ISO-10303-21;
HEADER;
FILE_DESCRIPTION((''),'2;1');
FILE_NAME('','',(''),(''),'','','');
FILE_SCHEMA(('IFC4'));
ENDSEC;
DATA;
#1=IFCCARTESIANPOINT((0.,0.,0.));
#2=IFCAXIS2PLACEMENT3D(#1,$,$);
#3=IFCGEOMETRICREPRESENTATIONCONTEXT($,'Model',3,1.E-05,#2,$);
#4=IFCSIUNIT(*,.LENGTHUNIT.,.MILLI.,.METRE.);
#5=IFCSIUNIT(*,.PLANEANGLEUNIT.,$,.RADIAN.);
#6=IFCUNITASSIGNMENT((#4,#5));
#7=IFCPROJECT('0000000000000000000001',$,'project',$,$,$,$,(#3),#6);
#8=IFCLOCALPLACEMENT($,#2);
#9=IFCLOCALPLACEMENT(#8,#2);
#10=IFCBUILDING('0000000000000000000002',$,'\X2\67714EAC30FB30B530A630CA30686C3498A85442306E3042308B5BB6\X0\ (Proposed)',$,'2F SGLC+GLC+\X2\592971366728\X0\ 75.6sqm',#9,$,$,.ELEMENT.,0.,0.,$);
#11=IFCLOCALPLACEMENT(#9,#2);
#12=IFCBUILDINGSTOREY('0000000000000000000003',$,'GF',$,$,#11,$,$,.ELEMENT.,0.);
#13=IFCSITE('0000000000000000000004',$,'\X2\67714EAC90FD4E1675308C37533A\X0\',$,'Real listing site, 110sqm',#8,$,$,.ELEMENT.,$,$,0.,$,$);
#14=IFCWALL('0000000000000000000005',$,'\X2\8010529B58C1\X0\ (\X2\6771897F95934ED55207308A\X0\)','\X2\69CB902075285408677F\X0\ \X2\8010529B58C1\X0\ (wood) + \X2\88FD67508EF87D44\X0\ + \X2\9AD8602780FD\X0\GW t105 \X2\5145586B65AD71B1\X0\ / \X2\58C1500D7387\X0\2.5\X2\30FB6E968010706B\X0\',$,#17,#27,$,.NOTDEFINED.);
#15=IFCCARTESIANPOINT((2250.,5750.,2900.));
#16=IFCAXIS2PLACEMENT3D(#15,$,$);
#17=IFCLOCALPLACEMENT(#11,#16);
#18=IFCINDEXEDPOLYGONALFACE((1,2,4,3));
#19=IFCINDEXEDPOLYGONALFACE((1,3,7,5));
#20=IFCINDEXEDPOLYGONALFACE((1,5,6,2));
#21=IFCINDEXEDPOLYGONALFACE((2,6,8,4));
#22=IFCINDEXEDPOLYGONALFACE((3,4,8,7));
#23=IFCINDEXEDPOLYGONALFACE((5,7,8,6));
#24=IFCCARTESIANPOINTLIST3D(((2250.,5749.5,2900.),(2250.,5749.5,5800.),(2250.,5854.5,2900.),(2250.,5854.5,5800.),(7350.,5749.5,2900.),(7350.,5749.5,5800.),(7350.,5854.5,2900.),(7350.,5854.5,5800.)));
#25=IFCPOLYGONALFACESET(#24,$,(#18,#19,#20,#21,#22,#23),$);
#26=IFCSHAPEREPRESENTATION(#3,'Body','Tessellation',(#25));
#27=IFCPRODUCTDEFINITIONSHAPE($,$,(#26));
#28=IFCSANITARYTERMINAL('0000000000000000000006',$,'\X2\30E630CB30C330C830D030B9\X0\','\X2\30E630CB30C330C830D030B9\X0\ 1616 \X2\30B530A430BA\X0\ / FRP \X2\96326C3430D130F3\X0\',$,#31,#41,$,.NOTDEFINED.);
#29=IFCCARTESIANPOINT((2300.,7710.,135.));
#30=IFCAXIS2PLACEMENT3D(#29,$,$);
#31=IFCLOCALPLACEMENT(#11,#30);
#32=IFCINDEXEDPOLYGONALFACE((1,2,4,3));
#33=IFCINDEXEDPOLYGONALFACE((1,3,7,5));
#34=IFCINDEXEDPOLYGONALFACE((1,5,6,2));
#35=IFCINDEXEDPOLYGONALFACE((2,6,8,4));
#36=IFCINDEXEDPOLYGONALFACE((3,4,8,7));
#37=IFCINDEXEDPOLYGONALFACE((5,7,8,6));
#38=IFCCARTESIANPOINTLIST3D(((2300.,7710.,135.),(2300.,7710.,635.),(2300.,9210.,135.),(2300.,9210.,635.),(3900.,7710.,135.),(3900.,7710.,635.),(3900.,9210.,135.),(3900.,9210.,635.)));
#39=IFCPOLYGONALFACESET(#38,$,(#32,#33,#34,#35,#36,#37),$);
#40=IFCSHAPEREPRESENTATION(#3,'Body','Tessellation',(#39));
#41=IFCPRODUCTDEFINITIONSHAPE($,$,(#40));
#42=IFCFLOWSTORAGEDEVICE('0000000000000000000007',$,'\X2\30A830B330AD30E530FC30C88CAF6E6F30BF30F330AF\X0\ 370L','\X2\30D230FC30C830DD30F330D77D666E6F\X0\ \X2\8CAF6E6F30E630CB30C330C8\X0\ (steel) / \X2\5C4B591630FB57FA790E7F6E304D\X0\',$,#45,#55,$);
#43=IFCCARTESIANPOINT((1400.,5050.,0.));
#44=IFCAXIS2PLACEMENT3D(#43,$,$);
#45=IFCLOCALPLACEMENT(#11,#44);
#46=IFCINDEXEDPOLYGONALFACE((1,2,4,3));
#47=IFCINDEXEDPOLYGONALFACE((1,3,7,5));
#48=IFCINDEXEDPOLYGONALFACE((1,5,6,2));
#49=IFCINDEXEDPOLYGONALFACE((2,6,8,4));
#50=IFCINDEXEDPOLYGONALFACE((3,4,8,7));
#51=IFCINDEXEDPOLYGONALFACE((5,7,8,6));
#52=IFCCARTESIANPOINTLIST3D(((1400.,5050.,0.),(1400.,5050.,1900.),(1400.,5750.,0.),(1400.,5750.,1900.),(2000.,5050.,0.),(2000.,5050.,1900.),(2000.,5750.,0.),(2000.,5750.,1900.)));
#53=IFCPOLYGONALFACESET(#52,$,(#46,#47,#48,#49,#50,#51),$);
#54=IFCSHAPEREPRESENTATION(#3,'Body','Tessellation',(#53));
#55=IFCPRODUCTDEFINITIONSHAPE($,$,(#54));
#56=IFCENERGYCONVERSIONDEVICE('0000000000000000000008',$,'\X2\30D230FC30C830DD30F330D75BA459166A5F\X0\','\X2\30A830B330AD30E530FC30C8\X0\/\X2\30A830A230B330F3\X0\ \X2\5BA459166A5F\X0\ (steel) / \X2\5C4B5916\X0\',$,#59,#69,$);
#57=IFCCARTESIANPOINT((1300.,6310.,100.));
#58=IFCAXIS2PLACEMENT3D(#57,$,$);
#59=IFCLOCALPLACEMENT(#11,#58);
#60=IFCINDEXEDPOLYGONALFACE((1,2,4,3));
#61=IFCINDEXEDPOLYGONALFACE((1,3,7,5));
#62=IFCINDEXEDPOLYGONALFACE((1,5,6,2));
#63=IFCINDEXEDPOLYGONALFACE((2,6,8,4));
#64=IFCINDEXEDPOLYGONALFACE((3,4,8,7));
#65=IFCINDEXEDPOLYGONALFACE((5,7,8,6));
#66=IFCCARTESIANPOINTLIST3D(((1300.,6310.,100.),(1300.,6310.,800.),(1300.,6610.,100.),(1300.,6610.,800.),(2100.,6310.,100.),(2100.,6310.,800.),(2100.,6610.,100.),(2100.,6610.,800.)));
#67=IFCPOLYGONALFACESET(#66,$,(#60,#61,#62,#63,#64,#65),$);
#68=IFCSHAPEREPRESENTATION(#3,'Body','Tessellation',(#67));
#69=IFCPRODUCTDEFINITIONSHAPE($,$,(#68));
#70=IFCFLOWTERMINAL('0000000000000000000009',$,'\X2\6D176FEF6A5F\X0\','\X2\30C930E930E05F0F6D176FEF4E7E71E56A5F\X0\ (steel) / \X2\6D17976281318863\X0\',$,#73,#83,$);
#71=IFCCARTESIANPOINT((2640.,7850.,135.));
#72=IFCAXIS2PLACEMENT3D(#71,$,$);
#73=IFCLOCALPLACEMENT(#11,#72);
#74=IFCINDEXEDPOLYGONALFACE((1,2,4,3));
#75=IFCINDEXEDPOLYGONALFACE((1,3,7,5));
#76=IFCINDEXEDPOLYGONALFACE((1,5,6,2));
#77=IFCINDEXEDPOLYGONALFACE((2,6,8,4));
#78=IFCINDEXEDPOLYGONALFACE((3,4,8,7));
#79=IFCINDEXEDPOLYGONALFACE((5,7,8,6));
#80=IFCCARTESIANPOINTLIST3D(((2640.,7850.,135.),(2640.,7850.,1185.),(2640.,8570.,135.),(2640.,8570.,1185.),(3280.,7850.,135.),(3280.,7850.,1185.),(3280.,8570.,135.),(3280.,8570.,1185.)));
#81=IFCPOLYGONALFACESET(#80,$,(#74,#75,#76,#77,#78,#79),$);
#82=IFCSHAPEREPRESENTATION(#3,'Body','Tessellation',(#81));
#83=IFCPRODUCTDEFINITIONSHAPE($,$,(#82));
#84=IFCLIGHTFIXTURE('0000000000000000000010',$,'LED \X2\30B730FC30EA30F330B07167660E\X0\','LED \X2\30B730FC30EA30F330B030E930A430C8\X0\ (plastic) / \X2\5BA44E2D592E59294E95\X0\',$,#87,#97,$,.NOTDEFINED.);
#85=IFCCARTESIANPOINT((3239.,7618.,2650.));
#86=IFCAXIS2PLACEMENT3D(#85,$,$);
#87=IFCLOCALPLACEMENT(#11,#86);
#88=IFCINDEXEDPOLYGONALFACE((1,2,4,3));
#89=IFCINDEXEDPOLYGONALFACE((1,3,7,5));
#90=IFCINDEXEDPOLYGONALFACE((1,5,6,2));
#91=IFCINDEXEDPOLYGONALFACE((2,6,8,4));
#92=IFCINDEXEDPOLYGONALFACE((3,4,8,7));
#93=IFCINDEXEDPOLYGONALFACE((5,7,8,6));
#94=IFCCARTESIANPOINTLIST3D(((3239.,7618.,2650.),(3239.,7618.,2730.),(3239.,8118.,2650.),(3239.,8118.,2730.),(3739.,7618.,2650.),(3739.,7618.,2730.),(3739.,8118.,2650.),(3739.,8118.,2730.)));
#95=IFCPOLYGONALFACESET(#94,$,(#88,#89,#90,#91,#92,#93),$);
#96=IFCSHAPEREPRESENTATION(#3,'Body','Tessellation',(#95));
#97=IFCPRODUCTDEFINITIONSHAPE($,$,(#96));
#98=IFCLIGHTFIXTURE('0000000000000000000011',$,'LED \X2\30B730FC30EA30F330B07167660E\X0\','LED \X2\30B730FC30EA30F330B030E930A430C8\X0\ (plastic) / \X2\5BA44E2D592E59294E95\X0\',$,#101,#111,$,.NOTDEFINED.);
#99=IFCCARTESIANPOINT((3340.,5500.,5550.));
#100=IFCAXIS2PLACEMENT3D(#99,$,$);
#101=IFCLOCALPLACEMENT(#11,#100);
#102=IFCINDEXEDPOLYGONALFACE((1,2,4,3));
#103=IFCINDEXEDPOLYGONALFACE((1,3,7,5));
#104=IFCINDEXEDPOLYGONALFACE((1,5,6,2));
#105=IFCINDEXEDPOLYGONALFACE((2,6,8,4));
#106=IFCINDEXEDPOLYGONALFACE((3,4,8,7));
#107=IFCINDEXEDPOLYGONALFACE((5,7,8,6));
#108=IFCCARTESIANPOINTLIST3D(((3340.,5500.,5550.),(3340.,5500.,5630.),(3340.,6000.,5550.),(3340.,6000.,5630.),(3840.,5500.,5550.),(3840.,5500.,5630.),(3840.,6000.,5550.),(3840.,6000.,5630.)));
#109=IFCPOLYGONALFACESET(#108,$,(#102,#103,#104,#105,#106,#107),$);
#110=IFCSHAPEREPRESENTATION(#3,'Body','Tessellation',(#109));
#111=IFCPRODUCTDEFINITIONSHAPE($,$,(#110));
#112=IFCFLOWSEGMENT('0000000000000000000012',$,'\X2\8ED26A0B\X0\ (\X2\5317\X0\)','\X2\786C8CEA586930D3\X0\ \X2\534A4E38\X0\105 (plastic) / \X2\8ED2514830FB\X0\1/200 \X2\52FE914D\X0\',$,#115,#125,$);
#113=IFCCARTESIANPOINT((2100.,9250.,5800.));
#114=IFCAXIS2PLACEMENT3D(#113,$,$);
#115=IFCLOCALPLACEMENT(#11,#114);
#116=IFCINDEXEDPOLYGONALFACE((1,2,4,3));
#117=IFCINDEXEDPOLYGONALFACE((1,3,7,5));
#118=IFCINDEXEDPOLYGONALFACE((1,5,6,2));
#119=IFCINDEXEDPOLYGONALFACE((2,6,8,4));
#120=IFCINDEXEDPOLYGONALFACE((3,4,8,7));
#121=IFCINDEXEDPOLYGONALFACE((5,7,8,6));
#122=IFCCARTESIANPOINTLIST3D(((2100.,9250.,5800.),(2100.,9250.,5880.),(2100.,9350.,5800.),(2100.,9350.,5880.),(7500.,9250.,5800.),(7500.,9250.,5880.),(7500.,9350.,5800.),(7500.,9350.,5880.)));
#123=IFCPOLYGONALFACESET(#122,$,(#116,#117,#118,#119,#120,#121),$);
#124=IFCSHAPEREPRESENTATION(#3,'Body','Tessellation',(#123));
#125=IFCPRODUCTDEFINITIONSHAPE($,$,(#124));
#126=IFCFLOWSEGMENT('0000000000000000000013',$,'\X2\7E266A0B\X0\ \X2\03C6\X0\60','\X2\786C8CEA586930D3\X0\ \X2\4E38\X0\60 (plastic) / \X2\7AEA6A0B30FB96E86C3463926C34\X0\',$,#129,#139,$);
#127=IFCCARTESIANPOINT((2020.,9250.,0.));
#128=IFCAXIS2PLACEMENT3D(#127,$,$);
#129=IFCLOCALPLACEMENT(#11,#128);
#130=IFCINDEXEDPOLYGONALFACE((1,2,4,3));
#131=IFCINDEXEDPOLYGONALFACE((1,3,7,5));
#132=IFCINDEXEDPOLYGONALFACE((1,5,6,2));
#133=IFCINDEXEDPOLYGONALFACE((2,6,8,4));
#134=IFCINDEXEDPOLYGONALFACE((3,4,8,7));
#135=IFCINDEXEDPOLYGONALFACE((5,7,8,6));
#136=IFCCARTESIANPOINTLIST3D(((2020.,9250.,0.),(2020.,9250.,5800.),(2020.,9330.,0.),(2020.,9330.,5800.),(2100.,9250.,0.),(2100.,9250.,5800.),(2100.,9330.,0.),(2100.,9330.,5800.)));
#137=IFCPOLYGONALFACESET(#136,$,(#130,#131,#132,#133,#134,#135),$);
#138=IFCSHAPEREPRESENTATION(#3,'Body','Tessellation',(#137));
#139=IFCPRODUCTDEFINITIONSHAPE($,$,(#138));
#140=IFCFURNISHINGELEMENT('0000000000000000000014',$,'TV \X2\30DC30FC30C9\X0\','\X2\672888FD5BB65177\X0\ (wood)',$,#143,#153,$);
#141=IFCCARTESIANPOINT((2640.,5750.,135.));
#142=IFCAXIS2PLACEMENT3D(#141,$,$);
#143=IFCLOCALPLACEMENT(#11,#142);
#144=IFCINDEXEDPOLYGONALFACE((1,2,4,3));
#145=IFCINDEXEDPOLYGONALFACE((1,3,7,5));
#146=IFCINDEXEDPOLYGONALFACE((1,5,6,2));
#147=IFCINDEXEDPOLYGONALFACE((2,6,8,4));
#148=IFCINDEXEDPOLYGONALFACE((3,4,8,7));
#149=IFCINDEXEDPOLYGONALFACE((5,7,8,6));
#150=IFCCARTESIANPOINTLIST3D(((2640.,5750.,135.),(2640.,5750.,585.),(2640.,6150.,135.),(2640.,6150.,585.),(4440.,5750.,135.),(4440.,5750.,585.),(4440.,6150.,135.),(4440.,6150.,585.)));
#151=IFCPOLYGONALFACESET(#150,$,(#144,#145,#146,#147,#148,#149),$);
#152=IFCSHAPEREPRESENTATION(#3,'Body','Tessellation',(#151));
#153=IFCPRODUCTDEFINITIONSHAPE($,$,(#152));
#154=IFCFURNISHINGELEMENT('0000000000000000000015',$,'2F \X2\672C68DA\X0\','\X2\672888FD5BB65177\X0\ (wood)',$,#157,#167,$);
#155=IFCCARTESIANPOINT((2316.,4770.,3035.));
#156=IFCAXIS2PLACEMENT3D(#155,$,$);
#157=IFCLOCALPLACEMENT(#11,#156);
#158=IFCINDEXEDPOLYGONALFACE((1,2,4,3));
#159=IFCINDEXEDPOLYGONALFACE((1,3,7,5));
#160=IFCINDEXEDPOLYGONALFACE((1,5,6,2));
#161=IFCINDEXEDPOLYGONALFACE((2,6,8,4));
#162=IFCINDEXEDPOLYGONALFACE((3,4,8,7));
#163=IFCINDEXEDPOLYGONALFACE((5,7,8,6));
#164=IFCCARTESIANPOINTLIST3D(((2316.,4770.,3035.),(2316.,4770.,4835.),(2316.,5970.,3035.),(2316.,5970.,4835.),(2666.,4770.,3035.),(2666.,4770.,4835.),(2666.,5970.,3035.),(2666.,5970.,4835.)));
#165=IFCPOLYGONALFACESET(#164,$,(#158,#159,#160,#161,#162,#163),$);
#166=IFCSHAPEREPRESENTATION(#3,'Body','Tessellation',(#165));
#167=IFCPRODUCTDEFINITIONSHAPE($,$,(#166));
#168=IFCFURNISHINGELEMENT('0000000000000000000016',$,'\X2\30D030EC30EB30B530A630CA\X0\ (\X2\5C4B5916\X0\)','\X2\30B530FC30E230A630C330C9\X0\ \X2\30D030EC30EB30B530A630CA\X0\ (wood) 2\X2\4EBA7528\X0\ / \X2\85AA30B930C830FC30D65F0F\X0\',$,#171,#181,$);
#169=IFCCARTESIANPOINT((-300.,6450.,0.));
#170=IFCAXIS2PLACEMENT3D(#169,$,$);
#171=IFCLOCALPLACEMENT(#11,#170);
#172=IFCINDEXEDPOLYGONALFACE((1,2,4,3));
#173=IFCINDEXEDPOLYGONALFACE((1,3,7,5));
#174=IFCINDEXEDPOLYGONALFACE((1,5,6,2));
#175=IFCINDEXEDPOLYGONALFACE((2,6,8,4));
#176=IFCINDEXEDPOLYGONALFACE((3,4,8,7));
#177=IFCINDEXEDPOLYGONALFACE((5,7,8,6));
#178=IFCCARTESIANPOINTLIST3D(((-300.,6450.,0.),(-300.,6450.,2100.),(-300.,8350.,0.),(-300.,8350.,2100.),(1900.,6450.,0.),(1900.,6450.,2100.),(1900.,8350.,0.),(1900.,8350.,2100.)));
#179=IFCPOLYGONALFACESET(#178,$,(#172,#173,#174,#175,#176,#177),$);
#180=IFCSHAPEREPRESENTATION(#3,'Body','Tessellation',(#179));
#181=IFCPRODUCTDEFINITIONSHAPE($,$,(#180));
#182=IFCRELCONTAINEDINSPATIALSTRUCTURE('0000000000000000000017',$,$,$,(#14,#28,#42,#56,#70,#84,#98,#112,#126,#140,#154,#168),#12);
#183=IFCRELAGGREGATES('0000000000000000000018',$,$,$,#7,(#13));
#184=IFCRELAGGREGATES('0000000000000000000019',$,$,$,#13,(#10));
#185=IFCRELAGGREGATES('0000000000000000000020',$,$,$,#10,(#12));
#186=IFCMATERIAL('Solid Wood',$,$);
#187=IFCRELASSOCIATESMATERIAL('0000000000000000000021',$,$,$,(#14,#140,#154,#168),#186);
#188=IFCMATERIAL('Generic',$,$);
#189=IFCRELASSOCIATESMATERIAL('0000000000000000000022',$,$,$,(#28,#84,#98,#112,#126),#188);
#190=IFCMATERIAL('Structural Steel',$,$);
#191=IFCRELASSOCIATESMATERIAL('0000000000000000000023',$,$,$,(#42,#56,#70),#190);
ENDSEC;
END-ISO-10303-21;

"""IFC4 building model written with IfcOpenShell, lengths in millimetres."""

from ifc_helpers import new_model, si_unit, frame, frame_2d, origin, place, context, project, spatial, rectangle, extrude, material, element, save


model = new_model("IFC4")

# Units and contexts
model_context = context("Model", 3, precision=1e-05, world=origin())
ifc_project = project(units=[si_unit("LENGTHUNIT", "METRE", prefix="MILLI"), si_unit("PLANEANGLEUNIT", "RADIAN")], contexts=[model_context])

# Site, building, storey
site_placement = place(None, origin())
site = spatial("IfcSite", under=ifc_project, at=site_placement, Name="東京都世田谷区", ObjectType="Real listing site, 110sqm", CompositionType="ELEMENT", RefElevation=0.0)
building_placement = place(site_placement, origin())
building = spatial("IfcBuilding", under=site, at=building_placement, Name="東京・サウナと水風呂のある家 (Proposed)", ObjectType="2F SGLC+GLC+天然木 75.6sqm", CompositionType="ELEMENT", ElevationOfRefHeight=0.0, ElevationOfTerrain=0.0)
storey_placement = place(building_placement, origin())
storey = spatial("IfcBuildingStorey", under=building, at=storey_placement, Name="GF", CompositionType="ELEMENT", Elevation=0.0)

# Shared definitions
ifc_material_1 = material(Name="Solid Wood")

# Wall
wall_1_placement = place(storey_placement, frame((2250.0, 5750.0, 2900.0)))
element("IfcWall", 1, at=wall_1_placement, inside=storey, material=ifc_material_1, Name="耐力壁 (東西間仕切り)", Description="構造用合板 耐力壁 (wood) + 製材軸組 + 高性能GW t105 充填断熱 / 壁倍率2.5・準耐火", PredefinedType="NOTDEFINED", context=model_context, shape_type="SweptSolid", body=[
    extrude(rectangle(XDim=5100.0, YDim=105.0, at=frame_2d((2550.0, 52.0))), frame((2250.0, 5750.0, 2900.0)), (0.0, 0.0, 1.0), 2900.0),
])

# Sanitary terminal
ifc_material_2 = material(Name="Generic")
sanitary_terminal_placement = place(storey_placement, frame((2300.0, 7710.0, 135.0)))
element("IfcSanitaryTerminal", 2, at=sanitary_terminal_placement, inside=storey, material=ifc_material_2, Name="ユニットバス", Description="ユニットバス 1616 サイズ / FRP 防水パン", PredefinedType="NOTDEFINED", context=model_context, shape_type="SweptSolid", body=[
    extrude(rectangle(XDim=1600.0, YDim=1500.0, at=frame_2d((800.0, 750.0))), frame((2300.0, 7710.0, 135.0)), (0.0, 0.0, 1.0), 500.0),
])

# Flow storage device
ifc_material_3 = material(Name="Structural Steel")
flow_storage_device_placement = place(storey_placement, frame((1400.0, 5050.0, 0.0)))
element("IfcFlowStorageDevice", 3, at=flow_storage_device_placement, inside=storey, material=ifc_material_3, Name="エコキュート貯湯タンク 370L", Description="ヒートポンプ給湯 貯湯ユニット (steel) / 屋外・基礎置き", context=model_context, shape_type="SweptSolid", body=[
    extrude(rectangle(XDim=600.0, YDim=700.0, at=frame_2d((300.0, 350.0))), frame((1400.0, 5050.0, 0.0)), (0.0, 0.0, 1.0), 1900.0),
])

# Energy conversion device
energy_conversion_device_placement = place(storey_placement, frame((1300.0, 6310.0, 100.0)))
element("IfcEnergyConversionDevice", 4, at=energy_conversion_device_placement, inside=storey, material=ifc_material_3, Name="ヒートポンプ室外機", Description="エコキュート/エアコン 室外機 (steel) / 屋外", context=model_context, shape_type="SweptSolid", body=[
    extrude(rectangle(XDim=800.0, YDim=300.0, at=frame_2d((400.0, 150.0))), frame((1300.0, 6310.0, 100.0)), (0.0, 0.0, 1.0), 700.0),
])

# Flow terminal
flow_terminal_placement = place(storey_placement, frame((2640.0, 7850.0, 135.0)))
element("IfcFlowTerminal", 5, at=flow_terminal_placement, inside=storey, material=ifc_material_3, Name="洗濯機", Description="ドラム式洗濯乾燥機 (steel) / 洗面脱衣", context=model_context, shape_type="SweptSolid", body=[
    extrude(rectangle(XDim=640.0, YDim=720.0, at=frame_2d((320.0, 360.0))), frame((2640.0, 7850.0, 135.0)), (0.0, 0.0, 1.0), 1050.0),
])

# Light fixtures
light_fixture_1_placement = place(storey_placement, frame((3239.0, 7618.0, 2650.0)))
element("IfcLightFixture", 6, at=light_fixture_1_placement, inside=storey, material=ifc_material_2, Name="LED シーリング照明", Description="LED シーリングライト (plastic) / 室中央天井", PredefinedType="NOTDEFINED", context=model_context, shape_type="SweptSolid", body=[
    extrude(rectangle(XDim=500.0, YDim=500.0, at=frame_2d((250.0, 250.0))), frame((3239.0, 7618.0, 2650.0)), (0.0, 0.0, 1.0), 80.0),
])
light_fixture_2_placement = place(storey_placement, frame((3340.0, 5500.0, 5550.0)))
element("IfcLightFixture", 7, at=light_fixture_2_placement, inside=storey, material=ifc_material_2, Name="LED シーリング照明", Description="LED シーリングライト (plastic) / 室中央天井", PredefinedType="NOTDEFINED", context=model_context, shape_type="SweptSolid", body=[
    extrude(rectangle(XDim=500.0, YDim=500.0, at=frame_2d((250.0, 250.0))), frame((3340.0, 5500.0, 5550.0)), (0.0, 0.0, 1.0), 80.0),
])

# Flow segments
flow_segment_1_placement = place(storey_placement, frame((2100.0, 9250.0, 5800.0)))
element("IfcFlowSegment", 8, at=flow_segment_1_placement, inside=storey, material=ifc_material_2, Name="軒樋 (北)", Description="硬質塩ビ 半丸105 (plastic) / 軒先・1/200 勾配", context=model_context, shape_type="SweptSolid", body=[
    extrude(rectangle(XDim=5400.0, YDim=100.0, at=frame_2d((2700.0, 50.0))), frame((2100.0, 9250.0, 5800.0)), (0.0, 0.0, 1.0), 80.0),
])
flow_segment_2_placement = place(storey_placement, frame((2020.0, 9250.0, 0.0)))
element("IfcFlowSegment", 9, at=flow_segment_2_placement, inside=storey, material=ifc_material_2, Name="縦樋 φ60", Description="硬質塩ビ 丸60 (plastic) / 竪樋・雨水排水", context=model_context, shape_type="SweptSolid", body=[
    extrude(rectangle(XDim=80.0, YDim=80.0, at=frame_2d((40.0, 40.0))), frame((2020.0, 9250.0, 0.0)), (0.0, 0.0, 1.0), 5800.0),
])

# Furnishing elements
furnishing_1_placement = place(storey_placement, frame((2640.0, 5750.0, 135.0)))
element("IfcFurnishingElement", 10, at=furnishing_1_placement, inside=storey, material=ifc_material_1, Name="TV ボード", Description="木製家具 (wood)", context=model_context, shape_type="SweptSolid", body=[
    extrude(rectangle(XDim=1800.0, YDim=400.0, at=frame_2d((900.0, 200.0))), frame((2640.0, 5750.0, 135.0)), (0.0, 0.0, 1.0), 450.0),
])
furnishing_2_placement = place(storey_placement, frame((2316.0, 4770.0, 3035.0)))
element("IfcFurnishingElement", 11, at=furnishing_2_placement, inside=storey, material=ifc_material_1, Name="2F 本棚", Description="木製家具 (wood)", context=model_context, shape_type="SweptSolid", body=[
    extrude(rectangle(XDim=350.0, YDim=1200.0, at=frame_2d((175.0, 600.0))), frame((2316.0, 4770.0, 3035.0)), (0.0, 0.0, 1.0), 1800.0),
])
furnishing_3_placement = place(storey_placement, frame((-300.0, 6450.0, 0.0)))
element("IfcFurnishingElement", 12, at=furnishing_3_placement, inside=storey, material=ifc_material_1, Name="バレルサウナ (屋外)", Description="サーモウッド バレルサウナ (wood) 2人用 / 薪ストーブ式", context=model_context, shape_type="SweptSolid", body=[
    extrude(rectangle(XDim=2200.0, YDim=1900.0, at=frame_2d((1100.0, 950.0))), frame((-300.0, 6450.0, 0.0)), (0.0, 0.0, 1.0), 2100.0),
])

save(model, "model.ifc")
